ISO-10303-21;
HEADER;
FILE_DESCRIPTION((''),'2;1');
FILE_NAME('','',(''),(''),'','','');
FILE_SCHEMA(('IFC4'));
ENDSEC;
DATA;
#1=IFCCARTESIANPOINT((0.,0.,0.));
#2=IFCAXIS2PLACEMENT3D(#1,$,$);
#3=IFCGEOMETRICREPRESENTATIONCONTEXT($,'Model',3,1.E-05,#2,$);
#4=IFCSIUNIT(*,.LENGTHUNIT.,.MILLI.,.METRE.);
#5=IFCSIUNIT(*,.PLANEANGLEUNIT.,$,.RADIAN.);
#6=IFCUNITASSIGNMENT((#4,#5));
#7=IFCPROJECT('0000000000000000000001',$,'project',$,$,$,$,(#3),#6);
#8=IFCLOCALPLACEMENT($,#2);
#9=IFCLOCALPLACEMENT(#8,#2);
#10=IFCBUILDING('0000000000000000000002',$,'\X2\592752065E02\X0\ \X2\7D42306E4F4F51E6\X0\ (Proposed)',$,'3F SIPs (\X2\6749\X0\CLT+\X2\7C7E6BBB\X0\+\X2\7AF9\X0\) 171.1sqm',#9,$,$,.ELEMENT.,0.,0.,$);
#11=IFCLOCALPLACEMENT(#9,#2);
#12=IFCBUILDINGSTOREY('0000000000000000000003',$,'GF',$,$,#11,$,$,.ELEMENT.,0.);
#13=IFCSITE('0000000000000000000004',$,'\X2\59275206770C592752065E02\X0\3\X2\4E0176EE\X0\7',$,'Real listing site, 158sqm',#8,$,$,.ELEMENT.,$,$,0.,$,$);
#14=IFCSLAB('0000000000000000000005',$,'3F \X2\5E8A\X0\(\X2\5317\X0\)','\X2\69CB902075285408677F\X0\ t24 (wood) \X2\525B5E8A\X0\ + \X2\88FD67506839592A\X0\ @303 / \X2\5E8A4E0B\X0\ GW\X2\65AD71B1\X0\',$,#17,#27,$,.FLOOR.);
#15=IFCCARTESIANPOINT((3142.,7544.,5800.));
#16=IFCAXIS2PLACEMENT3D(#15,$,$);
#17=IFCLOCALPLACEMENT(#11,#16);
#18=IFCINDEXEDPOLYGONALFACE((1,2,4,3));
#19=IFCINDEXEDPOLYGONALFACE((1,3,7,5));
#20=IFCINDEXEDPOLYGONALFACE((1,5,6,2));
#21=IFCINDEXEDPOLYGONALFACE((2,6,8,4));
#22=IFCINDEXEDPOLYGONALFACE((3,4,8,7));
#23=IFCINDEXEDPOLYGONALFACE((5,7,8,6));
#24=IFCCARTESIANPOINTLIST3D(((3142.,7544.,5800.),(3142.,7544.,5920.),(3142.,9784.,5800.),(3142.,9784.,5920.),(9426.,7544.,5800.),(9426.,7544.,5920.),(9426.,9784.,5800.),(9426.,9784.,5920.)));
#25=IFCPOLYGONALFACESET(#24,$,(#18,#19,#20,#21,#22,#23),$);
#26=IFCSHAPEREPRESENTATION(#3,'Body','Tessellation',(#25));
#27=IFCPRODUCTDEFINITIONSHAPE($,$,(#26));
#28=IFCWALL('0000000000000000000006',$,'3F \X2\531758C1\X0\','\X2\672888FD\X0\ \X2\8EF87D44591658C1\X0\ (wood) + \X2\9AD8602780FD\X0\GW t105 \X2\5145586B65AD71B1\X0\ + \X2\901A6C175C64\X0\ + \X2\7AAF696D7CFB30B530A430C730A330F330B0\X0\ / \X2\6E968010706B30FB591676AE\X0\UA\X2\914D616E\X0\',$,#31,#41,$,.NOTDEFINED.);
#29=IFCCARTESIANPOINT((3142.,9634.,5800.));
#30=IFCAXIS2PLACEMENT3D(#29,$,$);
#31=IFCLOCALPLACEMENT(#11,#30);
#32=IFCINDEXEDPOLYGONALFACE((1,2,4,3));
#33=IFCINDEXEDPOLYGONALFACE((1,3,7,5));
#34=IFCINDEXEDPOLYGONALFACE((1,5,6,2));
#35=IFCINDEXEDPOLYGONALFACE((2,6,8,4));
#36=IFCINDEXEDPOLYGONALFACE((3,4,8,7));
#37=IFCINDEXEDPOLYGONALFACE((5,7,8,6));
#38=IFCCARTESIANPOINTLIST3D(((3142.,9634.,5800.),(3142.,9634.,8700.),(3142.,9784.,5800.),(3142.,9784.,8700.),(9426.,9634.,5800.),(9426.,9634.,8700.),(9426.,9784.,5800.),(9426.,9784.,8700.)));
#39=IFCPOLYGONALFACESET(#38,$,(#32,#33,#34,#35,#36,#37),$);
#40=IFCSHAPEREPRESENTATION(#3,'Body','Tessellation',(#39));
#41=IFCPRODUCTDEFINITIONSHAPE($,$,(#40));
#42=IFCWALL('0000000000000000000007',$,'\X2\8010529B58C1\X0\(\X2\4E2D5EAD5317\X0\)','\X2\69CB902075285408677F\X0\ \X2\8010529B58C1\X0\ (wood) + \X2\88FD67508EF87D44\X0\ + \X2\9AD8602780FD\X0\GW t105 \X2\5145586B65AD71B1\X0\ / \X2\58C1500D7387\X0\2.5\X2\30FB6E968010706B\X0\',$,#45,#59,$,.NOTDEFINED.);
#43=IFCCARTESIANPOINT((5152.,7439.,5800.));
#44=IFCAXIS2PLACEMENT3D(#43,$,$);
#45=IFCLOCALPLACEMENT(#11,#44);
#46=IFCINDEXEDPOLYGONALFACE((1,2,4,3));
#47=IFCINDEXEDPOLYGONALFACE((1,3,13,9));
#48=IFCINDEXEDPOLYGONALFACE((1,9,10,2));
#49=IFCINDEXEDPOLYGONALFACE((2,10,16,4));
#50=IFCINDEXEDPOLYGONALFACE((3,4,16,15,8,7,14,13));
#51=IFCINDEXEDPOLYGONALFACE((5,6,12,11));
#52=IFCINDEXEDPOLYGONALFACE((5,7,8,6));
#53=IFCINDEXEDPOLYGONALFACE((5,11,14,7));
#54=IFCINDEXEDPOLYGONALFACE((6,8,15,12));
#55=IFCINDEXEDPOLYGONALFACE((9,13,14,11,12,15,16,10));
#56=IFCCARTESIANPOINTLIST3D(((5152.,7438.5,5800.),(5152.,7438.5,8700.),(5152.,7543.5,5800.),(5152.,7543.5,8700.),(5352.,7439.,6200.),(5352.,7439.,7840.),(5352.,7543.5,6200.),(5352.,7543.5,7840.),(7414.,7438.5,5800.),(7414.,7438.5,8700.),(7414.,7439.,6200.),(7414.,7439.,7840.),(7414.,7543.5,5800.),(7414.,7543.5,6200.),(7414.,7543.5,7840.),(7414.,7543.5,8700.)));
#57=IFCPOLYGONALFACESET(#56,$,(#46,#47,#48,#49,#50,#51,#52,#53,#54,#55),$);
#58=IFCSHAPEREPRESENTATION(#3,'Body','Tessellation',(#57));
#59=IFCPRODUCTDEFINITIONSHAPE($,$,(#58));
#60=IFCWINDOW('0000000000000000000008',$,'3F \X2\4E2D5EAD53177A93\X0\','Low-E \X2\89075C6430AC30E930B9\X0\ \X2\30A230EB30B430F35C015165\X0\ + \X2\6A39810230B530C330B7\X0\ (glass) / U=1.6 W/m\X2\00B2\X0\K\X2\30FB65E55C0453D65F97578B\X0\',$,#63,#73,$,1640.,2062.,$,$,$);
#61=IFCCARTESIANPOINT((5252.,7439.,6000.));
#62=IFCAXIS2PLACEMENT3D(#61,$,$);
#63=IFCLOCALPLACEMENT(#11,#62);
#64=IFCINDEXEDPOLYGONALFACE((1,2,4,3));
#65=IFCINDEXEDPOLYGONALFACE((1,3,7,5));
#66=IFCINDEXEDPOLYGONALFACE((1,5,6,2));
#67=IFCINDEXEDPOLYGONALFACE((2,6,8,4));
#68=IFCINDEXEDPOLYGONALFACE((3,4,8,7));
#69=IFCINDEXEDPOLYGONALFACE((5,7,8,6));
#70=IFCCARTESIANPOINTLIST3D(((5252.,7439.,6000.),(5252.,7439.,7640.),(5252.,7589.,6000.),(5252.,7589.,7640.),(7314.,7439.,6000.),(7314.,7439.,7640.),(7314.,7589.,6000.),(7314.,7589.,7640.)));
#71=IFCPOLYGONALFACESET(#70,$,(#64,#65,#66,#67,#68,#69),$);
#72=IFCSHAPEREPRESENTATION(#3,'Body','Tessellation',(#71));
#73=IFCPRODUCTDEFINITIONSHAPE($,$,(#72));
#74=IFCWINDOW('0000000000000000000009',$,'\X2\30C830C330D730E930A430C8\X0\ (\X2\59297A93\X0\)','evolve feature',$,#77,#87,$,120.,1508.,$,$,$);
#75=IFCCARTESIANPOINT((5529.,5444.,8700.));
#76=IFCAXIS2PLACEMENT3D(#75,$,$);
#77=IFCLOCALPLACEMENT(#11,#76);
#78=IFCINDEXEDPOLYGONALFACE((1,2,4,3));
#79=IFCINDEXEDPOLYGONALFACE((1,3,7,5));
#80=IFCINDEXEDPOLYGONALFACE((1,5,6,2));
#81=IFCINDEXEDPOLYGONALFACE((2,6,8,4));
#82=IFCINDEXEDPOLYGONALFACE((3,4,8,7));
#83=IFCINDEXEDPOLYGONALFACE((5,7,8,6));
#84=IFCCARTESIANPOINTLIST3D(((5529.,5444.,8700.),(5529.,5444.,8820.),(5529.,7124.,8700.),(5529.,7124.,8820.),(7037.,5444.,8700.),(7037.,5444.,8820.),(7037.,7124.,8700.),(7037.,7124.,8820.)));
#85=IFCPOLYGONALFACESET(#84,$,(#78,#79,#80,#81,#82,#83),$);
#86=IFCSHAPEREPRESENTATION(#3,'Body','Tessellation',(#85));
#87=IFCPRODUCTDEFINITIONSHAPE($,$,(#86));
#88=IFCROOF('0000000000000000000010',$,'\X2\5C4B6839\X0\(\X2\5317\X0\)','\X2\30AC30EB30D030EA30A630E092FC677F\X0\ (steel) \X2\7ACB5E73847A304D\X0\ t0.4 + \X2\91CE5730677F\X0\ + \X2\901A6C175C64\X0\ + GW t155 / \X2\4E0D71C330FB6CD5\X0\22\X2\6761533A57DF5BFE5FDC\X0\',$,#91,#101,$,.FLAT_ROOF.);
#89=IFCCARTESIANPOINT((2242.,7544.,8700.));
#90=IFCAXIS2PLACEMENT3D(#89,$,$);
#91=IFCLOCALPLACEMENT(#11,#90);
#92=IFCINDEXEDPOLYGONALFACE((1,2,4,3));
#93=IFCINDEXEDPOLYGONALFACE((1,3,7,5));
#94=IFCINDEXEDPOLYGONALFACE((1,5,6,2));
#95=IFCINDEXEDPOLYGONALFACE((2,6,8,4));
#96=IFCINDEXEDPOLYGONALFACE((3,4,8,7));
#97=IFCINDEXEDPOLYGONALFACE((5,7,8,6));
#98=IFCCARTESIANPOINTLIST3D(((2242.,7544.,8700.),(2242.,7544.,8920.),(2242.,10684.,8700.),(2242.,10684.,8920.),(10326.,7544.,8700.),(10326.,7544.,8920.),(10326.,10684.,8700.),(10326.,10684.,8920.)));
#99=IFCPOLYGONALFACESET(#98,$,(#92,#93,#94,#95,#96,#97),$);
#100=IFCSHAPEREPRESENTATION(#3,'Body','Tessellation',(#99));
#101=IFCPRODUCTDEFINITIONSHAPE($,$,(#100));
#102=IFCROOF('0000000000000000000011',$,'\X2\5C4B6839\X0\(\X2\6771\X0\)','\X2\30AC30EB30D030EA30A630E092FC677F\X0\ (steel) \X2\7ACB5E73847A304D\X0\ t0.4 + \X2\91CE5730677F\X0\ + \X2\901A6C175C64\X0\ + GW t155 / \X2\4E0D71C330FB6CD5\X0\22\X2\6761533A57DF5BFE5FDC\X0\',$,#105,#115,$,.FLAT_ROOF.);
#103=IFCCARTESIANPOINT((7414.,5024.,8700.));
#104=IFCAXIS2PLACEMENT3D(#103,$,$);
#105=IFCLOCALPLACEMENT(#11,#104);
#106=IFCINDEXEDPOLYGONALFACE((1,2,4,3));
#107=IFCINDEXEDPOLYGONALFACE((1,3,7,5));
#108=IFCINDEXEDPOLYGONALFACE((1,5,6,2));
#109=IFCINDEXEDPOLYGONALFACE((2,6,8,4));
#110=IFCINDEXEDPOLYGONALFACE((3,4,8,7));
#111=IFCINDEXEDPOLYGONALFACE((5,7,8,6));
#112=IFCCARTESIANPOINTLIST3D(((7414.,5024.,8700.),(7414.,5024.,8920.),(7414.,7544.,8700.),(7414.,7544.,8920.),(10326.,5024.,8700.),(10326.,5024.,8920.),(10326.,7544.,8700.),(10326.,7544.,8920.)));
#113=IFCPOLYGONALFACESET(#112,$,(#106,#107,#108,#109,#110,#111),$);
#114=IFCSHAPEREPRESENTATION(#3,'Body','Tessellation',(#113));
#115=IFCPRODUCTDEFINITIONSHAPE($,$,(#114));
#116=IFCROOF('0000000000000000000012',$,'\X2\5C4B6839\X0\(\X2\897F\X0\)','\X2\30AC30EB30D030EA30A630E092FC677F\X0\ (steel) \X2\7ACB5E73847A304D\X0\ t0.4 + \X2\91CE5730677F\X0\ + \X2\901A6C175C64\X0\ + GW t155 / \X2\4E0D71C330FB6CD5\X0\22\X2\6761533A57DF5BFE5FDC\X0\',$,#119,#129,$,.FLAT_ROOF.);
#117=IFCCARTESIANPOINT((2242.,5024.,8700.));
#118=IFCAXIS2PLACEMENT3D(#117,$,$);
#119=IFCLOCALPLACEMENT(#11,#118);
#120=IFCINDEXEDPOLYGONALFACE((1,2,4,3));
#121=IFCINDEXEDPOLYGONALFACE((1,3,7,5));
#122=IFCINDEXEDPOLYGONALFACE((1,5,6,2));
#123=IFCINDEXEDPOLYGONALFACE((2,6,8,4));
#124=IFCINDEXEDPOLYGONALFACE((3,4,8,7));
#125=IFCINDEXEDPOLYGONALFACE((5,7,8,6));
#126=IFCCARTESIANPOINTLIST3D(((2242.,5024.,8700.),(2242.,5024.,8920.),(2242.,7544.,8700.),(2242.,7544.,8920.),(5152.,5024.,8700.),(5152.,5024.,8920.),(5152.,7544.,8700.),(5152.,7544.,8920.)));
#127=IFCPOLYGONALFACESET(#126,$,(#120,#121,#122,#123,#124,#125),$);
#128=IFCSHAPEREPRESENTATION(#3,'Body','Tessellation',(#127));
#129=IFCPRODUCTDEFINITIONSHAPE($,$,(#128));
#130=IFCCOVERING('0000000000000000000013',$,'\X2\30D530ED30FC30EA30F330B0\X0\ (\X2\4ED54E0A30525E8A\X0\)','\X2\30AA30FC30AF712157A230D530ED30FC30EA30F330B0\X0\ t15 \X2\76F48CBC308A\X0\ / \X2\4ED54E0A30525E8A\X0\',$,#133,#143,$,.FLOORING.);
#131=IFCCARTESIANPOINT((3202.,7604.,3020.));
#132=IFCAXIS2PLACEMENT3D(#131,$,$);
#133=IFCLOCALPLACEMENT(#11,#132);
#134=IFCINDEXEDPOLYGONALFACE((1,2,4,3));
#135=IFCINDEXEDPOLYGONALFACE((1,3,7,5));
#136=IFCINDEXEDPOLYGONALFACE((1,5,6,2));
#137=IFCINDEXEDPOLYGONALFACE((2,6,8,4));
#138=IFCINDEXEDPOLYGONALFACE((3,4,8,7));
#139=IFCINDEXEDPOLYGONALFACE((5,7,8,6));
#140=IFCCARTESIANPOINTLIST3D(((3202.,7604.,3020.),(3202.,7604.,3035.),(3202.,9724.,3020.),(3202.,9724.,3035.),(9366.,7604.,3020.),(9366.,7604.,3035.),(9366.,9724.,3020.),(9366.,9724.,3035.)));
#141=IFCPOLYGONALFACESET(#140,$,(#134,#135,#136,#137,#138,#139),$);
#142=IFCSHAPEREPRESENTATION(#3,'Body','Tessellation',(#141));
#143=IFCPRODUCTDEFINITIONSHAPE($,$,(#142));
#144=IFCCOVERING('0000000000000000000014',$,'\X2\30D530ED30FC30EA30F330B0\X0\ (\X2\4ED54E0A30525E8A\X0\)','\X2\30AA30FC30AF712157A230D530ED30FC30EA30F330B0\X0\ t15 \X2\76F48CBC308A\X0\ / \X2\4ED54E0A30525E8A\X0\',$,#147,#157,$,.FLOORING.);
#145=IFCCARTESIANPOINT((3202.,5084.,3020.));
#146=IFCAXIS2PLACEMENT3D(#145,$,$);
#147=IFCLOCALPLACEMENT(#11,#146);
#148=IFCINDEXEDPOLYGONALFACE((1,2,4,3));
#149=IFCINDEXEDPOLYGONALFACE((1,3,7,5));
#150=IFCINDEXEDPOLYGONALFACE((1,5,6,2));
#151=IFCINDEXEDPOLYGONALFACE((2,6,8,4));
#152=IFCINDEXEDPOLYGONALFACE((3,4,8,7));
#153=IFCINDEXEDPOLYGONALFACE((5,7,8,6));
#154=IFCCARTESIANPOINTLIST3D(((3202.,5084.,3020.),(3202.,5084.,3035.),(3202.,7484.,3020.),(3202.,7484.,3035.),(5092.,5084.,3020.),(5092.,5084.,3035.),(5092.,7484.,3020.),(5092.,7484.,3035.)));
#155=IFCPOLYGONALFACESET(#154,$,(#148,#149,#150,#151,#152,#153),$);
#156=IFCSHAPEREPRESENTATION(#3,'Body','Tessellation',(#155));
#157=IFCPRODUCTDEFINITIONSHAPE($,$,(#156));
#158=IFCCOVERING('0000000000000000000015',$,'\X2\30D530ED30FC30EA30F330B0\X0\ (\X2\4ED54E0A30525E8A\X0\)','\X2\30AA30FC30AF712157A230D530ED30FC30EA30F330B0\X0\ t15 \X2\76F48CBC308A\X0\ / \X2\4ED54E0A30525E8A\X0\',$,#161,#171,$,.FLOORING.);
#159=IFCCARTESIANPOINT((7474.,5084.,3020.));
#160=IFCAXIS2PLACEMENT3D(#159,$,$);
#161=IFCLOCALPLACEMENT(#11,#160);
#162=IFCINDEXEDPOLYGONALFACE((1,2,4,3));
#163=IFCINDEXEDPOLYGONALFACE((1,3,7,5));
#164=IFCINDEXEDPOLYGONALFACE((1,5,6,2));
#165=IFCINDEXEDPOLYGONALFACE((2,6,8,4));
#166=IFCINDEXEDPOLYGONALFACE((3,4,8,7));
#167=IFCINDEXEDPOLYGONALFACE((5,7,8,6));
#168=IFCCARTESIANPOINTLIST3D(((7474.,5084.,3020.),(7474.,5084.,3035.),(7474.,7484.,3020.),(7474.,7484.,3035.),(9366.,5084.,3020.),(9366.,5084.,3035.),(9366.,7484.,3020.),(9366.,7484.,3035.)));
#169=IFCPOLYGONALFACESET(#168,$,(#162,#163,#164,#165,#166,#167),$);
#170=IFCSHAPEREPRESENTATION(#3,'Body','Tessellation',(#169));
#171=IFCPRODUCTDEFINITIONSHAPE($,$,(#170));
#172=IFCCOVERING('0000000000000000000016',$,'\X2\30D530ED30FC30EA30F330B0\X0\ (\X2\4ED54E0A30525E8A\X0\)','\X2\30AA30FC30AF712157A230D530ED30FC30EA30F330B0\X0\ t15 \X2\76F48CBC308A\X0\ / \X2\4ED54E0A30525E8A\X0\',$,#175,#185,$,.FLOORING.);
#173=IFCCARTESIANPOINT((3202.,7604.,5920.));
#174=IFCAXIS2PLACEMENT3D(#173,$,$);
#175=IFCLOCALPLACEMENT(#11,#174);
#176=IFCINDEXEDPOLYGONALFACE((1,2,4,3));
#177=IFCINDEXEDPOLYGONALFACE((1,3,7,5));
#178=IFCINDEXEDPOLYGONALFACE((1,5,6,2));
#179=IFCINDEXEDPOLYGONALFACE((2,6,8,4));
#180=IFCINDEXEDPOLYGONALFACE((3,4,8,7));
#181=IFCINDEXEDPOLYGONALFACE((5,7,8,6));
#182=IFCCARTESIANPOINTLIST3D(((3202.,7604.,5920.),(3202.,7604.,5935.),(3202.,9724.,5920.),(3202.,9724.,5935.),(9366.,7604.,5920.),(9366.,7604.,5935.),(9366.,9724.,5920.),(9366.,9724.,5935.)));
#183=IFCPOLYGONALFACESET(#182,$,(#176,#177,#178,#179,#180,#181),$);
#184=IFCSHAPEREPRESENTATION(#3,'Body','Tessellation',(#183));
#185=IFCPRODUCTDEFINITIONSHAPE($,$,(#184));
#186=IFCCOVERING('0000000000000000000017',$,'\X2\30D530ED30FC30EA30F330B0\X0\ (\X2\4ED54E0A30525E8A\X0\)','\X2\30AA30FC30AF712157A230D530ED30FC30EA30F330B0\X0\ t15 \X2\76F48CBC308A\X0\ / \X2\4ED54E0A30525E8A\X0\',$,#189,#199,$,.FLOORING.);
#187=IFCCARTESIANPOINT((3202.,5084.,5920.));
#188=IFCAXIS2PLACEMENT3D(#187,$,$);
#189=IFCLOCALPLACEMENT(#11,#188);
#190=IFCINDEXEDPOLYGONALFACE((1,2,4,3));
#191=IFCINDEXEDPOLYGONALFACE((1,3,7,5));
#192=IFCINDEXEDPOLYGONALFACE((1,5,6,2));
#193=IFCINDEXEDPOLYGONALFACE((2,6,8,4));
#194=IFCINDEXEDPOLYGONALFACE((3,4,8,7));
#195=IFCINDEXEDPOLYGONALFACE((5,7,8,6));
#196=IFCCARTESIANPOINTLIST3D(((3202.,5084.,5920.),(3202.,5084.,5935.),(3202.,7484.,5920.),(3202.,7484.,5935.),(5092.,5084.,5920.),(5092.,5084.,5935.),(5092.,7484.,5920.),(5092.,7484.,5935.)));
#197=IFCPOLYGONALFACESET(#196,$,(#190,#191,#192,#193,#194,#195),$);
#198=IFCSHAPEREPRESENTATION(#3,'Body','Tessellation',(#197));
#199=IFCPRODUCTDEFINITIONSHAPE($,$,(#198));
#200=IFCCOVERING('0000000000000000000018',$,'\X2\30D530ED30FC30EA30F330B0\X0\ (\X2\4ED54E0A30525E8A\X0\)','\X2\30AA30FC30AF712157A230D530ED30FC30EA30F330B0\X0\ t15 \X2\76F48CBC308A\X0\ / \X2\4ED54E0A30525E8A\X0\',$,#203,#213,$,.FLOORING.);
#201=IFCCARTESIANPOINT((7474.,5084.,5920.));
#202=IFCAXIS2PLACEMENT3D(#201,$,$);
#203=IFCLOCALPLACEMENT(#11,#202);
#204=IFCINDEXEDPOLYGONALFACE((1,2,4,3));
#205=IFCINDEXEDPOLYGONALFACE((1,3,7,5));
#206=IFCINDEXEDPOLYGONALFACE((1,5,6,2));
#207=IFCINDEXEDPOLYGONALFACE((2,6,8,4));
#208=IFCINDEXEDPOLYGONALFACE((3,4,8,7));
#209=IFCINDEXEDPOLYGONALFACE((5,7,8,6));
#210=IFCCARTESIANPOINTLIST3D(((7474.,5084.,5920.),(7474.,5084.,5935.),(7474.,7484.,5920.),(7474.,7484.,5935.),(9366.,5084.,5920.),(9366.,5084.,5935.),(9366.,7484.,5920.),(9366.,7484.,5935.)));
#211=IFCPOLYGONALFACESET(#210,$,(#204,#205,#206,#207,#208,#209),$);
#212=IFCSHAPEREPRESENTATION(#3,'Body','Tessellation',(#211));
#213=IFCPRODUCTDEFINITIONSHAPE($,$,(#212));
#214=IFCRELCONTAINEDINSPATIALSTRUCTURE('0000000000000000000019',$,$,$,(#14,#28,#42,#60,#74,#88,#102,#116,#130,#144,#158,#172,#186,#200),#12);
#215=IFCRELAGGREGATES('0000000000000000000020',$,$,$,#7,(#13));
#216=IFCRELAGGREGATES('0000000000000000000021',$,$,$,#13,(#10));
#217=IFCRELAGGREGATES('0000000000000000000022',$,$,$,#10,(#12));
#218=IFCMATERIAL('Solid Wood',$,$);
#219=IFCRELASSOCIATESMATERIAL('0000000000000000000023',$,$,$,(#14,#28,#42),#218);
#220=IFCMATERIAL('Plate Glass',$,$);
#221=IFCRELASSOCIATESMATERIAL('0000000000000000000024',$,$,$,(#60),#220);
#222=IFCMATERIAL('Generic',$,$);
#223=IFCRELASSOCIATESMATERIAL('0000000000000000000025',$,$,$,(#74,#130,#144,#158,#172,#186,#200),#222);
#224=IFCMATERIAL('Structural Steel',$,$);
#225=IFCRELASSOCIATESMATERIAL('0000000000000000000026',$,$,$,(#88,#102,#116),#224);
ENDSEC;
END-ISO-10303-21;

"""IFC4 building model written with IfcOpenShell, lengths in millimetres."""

from ifc_helpers import new_model, si_unit, frame, frame_2d, origin, place, context, project, spatial, rectangle, extrude, material, element, fill, save


model = new_model("IFC4")

# Units and contexts
model_context = context("Model", 3, precision=1e-05, world=origin())
ifc_project = project(units=[si_unit("LENGTHUNIT", "METRE", prefix="MILLI"), si_unit("PLANEANGLEUNIT", "RADIAN")], contexts=[model_context])

# Site, building, storey
site_placement = place(None, origin())
site = spatial("IfcSite", under=ifc_project, at=site_placement, Name="大分県大分市3丁目7", ObjectType="Real listing site, 158sqm", CompositionType="ELEMENT", RefElevation=0.0)
building_placement = place(site_placement, origin())
building = spatial("IfcBuilding", under=site, at=building_placement, Name="大分市 終の住処 (Proposed)", ObjectType="3F SIPs (杉CLT+籾殻+竹) 171.1sqm", CompositionType="ELEMENT", ElevationOfRefHeight=0.0, ElevationOfTerrain=0.0)
storey_placement = place(building_placement, origin())
storey = spatial("IfcBuildingStorey", under=building, at=storey_placement, Name="GF", CompositionType="ELEMENT", Elevation=0.0)

# Slab
ifc_material_1 = material(Name="Solid Wood")
slab_placement = place(storey_placement, frame((3142.0, 7544.0, 5800.0)))
element("IfcSlab", 1, at=slab_placement, inside=storey, material=ifc_material_1, Name="3F 床(北)", Description="構造用合板 t24 (wood) 剛床 + 製材根太 @303 / 床下 GW断熱", PredefinedType="FLOOR", context=model_context, shape_type="SweptSolid", body=[
    extrude(rectangle(XDim=6284.0, YDim=2240.0, at=frame_2d((3142.0, 1120.0))), frame((3142.0, 7544.0, 5800.0)), (0.0, 0.0, 1.0), 120.0),
])

# Wall
wall_1_placement = place(storey_placement, frame((3142.0, 9634.0, 5800.0)))
element("IfcWall", 2, at=wall_1_placement, inside=storey, material=ifc_material_1, Name="3F 北壁", Description="木製 軸組外壁 (wood) + 高性能GW t105 充填断熱 + 通気層 + 窯業系サイディング / 準耐火・外皮UA配慮", PredefinedType="NOTDEFINED", context=model_context, shape_type="SweptSolid", body=[
    extrude(rectangle(XDim=6284.0, YDim=150.0, at=frame_2d((3142.0, 75.0))), frame((3142.0, 9634.0, 5800.0)), (0.0, 0.0, 1.0), 2900.0),
])

# Wall, opening, window
wall_2_placement = place(storey_placement, frame((5152.0, 7439.0, 5800.0)))
wall_2 = element("IfcWall", 3, at=wall_2_placement, inside=storey, material=ifc_material_1, Name="耐力壁(中庭北)", Description="構造用合板 耐力壁 (wood) + 製材軸組 + 高性能GW t105 充填断熱 / 壁倍率2.5・準耐火", PredefinedType="NOTDEFINED", context=model_context, shape_type="SweptSolid", body=[
    extrude(rectangle(XDim=2262.0, YDim=105.0, at=frame_2d((1131.0, 52.0))), frame((5152.0, 7439.0, 5800.0)), (0.0, 0.0, 1.0), 2900.0),
])
opening_placement = place(storey_placement, frame((5252.0, 7439.0, 6000.0)))
opening = element("IfcOpeningElement", 4, at=opening_placement, cuts=wall_2, PredefinedType="NOTDEFINED", context=model_context, shape_type="SweptSolid", body=[
    extrude(rectangle(XDim=2062.0, YDim=150.0, at=frame_2d((1031.0, 75.0))), frame((5252.0, 7439.0, 6000.0)), (0.0, 0.0, 1.0), 1640.0),
])
ifc_material_2 = material(Name="Plate Glass")
window_1_placement = place(storey_placement, frame((5252.0, 7439.0, 6000.0)))
window_1 = element("IfcWindow", 5, at=window_1_placement, inside=storey, material=ifc_material_2, Name="3F 中庭北窓", Description="Low-E 複層ガラス アルゴン封入 + 樹脂サッシ (glass) / U=1.6 W/m²K・日射取得型", OverallHeight=1640.0, OverallWidth=2062.0, context=model_context, shape_type="SweptSolid", body=[
    extrude(rectangle(XDim=2062.0, YDim=150.0, at=frame_2d((1031.0, 75.0))), frame((5252.0, 7439.0, 6000.0)), (0.0, 0.0, 1.0), 1640.0),
])
fill(opening, window_1)

# Window
ifc_material_3 = material(Name="Generic")
window_2_placement = place(storey_placement, frame((5529.0, 5444.0, 8700.0)))
element("IfcWindow", 6, at=window_2_placement, inside=storey, material=ifc_material_3, Name="トップライト (天窓)", Description="evolve feature", OverallHeight=120.0, OverallWidth=1508.0, context=model_context, shape_type="SweptSolid", body=[
    extrude(rectangle(XDim=1508.0, YDim=1680.0, at=frame_2d((754.0, 840.0))), frame((5529.0, 5444.0, 8700.0)), (0.0, 0.0, 1.0), 120.0),
])

# Roofs
ifc_material_4 = material(Name="Structural Steel")
roof_1_placement = place(storey_placement, frame((2242.0, 7544.0, 8700.0)))
element("IfcRoof", 7, at=roof_1_placement, inside=storey, material=ifc_material_4, Name="屋根(北)", Description="ガルバリウム鋼板 (steel) 立平葺き t0.4 + 野地板 + 通気層 + GW t155 / 不燃・法22条区域対応", PredefinedType="FLAT_ROOF", context=model_context, shape_type="SweptSolid", body=[
    extrude(rectangle(XDim=8084.0, YDim=3140.0, at=frame_2d((4042.0, 1570.0))), frame((2242.0, 7544.0, 8700.0)), (0.0, 0.0, 1.0), 220.0),
])
roof_2_placement = place(storey_placement, frame((7414.0, 5024.0, 8700.0)))
element("IfcRoof", 8, at=roof_2_placement, inside=storey, material=ifc_material_4, Name="屋根(東)", Description="ガルバリウム鋼板 (steel) 立平葺き t0.4 + 野地板 + 通気層 + GW t155 / 不燃・法22条区域対応", PredefinedType="FLAT_ROOF", context=model_context, shape_type="SweptSolid", body=[
    extrude(rectangle(XDim=2912.0, YDim=2520.0, at=frame_2d((1456.0, 1260.0))), frame((7414.0, 5024.0, 8700.0)), (0.0, 0.0, 1.0), 220.0),
])
roof_3_placement = place(storey_placement, frame((2242.0, 5024.0, 8700.0)))
element("IfcRoof", 9, at=roof_3_placement, inside=storey, material=ifc_material_4, Name="屋根(西)", Description="ガルバリウム鋼板 (steel) 立平葺き t0.4 + 野地板 + 通気層 + GW t155 / 不燃・法22条区域対応", PredefinedType="FLAT_ROOF", context=model_context, shape_type="SweptSolid", body=[
    extrude(rectangle(XDim=2910.0, YDim=2520.0, at=frame_2d((1455.0, 1260.0))), frame((2242.0, 5024.0, 8700.0)), (0.0, 0.0, 1.0), 220.0),
])

# Coverings
covering_1_placement = place(storey_placement, frame((3202.0, 7604.0, 3020.0)))
element("IfcCovering", 10, at=covering_1_placement, inside=storey, material=ifc_material_3, Name="フローリング (仕上げ床)", Description="オーク無垢フローリング t15 直貼り / 仕上げ床", PredefinedType="FLOORING", context=model_context, shape_type="SweptSolid", body=[
    extrude(rectangle(XDim=6164.0, YDim=2120.0, at=frame_2d((3082.0, 1060.0))), frame((3202.0, 7604.0, 3020.0)), (0.0, 0.0, 1.0), 15.0),
])
covering_2_placement = place(storey_placement, frame((3202.0, 5084.0, 3020.0)))
element("IfcCovering", 11, at=covering_2_placement, inside=storey, material=ifc_material_3, Name="フローリング (仕上げ床)", Description="オーク無垢フローリング t15 直貼り / 仕上げ床", PredefinedType="FLOORING", context=model_context, shape_type="SweptSolid", body=[
    extrude(rectangle(XDim=1890.0, YDim=2400.0, at=frame_2d((945.0, 1200.0))), frame((3202.0, 5084.0, 3020.0)), (0.0, 0.0, 1.0), 15.0),
])
covering_3_placement = place(storey_placement, frame((7474.0, 5084.0, 3020.0)))
element("IfcCovering", 12, at=covering_3_placement, inside=storey, material=ifc_material_3, Name="フローリング (仕上げ床)", Description="オーク無垢フローリング t15 直貼り / 仕上げ床", PredefinedType="FLOORING", context=model_context, shape_type="SweptSolid", body=[
    extrude(rectangle(XDim=1892.0, YDim=2400.0, at=frame_2d((946.0, 1200.0))), frame((7474.0, 5084.0, 3020.0)), (0.0, 0.0, 1.0), 15.0),
])
covering_4_placement = place(storey_placement, frame((3202.0, 7604.0, 5920.0)))
element("IfcCovering", 13, at=covering_4_placement, inside=storey, material=ifc_material_3, Name="フローリング (仕上げ床)", Description="オーク無垢フローリング t15 直貼り / 仕上げ床", PredefinedType="FLOORING", context=model_context, shape_type="SweptSolid", body=[
    extrude(rectangle(XDim=6164.0, YDim=2120.0, at=frame_2d((3082.0, 1060.0))), frame((3202.0, 7604.0, 5920.0)), (0.0, 0.0, 1.0), 15.0),
])
covering_5_placement = place(storey_placement, frame((3202.0, 5084.0, 5920.0)))
element("IfcCovering", 14, at=covering_5_placement, inside=storey, material=ifc_material_3, Name="フローリング (仕上げ床)", Description="オーク無垢フローリング t15 直貼り / 仕上げ床", PredefinedType="FLOORING", context=model_context, shape_type="SweptSolid", body=[
    extrude(rectangle(XDim=1890.0, YDim=2400.0, at=frame_2d((945.0, 1200.0))), frame((3202.0, 5084.0, 5920.0)), (0.0, 0.0, 1.0), 15.0),
])
covering_6_placement = place(storey_placement, frame((7474.0, 5084.0, 5920.0)))
element("IfcCovering", 15, at=covering_6_placement, inside=storey, material=ifc_material_3, Name="フローリング (仕上げ床)", Description="オーク無垢フローリング t15 直貼り / 仕上げ床", PredefinedType="FLOORING", context=model_context, shape_type="SweptSolid", body=[
    extrude(rectangle(XDim=1892.0, YDim=2400.0, at=frame_2d((946.0, 1200.0))), frame((7474.0, 5084.0, 5920.0)), (0.0, 0.0, 1.0), 15.0),
])

save(model, "model.ifc")
